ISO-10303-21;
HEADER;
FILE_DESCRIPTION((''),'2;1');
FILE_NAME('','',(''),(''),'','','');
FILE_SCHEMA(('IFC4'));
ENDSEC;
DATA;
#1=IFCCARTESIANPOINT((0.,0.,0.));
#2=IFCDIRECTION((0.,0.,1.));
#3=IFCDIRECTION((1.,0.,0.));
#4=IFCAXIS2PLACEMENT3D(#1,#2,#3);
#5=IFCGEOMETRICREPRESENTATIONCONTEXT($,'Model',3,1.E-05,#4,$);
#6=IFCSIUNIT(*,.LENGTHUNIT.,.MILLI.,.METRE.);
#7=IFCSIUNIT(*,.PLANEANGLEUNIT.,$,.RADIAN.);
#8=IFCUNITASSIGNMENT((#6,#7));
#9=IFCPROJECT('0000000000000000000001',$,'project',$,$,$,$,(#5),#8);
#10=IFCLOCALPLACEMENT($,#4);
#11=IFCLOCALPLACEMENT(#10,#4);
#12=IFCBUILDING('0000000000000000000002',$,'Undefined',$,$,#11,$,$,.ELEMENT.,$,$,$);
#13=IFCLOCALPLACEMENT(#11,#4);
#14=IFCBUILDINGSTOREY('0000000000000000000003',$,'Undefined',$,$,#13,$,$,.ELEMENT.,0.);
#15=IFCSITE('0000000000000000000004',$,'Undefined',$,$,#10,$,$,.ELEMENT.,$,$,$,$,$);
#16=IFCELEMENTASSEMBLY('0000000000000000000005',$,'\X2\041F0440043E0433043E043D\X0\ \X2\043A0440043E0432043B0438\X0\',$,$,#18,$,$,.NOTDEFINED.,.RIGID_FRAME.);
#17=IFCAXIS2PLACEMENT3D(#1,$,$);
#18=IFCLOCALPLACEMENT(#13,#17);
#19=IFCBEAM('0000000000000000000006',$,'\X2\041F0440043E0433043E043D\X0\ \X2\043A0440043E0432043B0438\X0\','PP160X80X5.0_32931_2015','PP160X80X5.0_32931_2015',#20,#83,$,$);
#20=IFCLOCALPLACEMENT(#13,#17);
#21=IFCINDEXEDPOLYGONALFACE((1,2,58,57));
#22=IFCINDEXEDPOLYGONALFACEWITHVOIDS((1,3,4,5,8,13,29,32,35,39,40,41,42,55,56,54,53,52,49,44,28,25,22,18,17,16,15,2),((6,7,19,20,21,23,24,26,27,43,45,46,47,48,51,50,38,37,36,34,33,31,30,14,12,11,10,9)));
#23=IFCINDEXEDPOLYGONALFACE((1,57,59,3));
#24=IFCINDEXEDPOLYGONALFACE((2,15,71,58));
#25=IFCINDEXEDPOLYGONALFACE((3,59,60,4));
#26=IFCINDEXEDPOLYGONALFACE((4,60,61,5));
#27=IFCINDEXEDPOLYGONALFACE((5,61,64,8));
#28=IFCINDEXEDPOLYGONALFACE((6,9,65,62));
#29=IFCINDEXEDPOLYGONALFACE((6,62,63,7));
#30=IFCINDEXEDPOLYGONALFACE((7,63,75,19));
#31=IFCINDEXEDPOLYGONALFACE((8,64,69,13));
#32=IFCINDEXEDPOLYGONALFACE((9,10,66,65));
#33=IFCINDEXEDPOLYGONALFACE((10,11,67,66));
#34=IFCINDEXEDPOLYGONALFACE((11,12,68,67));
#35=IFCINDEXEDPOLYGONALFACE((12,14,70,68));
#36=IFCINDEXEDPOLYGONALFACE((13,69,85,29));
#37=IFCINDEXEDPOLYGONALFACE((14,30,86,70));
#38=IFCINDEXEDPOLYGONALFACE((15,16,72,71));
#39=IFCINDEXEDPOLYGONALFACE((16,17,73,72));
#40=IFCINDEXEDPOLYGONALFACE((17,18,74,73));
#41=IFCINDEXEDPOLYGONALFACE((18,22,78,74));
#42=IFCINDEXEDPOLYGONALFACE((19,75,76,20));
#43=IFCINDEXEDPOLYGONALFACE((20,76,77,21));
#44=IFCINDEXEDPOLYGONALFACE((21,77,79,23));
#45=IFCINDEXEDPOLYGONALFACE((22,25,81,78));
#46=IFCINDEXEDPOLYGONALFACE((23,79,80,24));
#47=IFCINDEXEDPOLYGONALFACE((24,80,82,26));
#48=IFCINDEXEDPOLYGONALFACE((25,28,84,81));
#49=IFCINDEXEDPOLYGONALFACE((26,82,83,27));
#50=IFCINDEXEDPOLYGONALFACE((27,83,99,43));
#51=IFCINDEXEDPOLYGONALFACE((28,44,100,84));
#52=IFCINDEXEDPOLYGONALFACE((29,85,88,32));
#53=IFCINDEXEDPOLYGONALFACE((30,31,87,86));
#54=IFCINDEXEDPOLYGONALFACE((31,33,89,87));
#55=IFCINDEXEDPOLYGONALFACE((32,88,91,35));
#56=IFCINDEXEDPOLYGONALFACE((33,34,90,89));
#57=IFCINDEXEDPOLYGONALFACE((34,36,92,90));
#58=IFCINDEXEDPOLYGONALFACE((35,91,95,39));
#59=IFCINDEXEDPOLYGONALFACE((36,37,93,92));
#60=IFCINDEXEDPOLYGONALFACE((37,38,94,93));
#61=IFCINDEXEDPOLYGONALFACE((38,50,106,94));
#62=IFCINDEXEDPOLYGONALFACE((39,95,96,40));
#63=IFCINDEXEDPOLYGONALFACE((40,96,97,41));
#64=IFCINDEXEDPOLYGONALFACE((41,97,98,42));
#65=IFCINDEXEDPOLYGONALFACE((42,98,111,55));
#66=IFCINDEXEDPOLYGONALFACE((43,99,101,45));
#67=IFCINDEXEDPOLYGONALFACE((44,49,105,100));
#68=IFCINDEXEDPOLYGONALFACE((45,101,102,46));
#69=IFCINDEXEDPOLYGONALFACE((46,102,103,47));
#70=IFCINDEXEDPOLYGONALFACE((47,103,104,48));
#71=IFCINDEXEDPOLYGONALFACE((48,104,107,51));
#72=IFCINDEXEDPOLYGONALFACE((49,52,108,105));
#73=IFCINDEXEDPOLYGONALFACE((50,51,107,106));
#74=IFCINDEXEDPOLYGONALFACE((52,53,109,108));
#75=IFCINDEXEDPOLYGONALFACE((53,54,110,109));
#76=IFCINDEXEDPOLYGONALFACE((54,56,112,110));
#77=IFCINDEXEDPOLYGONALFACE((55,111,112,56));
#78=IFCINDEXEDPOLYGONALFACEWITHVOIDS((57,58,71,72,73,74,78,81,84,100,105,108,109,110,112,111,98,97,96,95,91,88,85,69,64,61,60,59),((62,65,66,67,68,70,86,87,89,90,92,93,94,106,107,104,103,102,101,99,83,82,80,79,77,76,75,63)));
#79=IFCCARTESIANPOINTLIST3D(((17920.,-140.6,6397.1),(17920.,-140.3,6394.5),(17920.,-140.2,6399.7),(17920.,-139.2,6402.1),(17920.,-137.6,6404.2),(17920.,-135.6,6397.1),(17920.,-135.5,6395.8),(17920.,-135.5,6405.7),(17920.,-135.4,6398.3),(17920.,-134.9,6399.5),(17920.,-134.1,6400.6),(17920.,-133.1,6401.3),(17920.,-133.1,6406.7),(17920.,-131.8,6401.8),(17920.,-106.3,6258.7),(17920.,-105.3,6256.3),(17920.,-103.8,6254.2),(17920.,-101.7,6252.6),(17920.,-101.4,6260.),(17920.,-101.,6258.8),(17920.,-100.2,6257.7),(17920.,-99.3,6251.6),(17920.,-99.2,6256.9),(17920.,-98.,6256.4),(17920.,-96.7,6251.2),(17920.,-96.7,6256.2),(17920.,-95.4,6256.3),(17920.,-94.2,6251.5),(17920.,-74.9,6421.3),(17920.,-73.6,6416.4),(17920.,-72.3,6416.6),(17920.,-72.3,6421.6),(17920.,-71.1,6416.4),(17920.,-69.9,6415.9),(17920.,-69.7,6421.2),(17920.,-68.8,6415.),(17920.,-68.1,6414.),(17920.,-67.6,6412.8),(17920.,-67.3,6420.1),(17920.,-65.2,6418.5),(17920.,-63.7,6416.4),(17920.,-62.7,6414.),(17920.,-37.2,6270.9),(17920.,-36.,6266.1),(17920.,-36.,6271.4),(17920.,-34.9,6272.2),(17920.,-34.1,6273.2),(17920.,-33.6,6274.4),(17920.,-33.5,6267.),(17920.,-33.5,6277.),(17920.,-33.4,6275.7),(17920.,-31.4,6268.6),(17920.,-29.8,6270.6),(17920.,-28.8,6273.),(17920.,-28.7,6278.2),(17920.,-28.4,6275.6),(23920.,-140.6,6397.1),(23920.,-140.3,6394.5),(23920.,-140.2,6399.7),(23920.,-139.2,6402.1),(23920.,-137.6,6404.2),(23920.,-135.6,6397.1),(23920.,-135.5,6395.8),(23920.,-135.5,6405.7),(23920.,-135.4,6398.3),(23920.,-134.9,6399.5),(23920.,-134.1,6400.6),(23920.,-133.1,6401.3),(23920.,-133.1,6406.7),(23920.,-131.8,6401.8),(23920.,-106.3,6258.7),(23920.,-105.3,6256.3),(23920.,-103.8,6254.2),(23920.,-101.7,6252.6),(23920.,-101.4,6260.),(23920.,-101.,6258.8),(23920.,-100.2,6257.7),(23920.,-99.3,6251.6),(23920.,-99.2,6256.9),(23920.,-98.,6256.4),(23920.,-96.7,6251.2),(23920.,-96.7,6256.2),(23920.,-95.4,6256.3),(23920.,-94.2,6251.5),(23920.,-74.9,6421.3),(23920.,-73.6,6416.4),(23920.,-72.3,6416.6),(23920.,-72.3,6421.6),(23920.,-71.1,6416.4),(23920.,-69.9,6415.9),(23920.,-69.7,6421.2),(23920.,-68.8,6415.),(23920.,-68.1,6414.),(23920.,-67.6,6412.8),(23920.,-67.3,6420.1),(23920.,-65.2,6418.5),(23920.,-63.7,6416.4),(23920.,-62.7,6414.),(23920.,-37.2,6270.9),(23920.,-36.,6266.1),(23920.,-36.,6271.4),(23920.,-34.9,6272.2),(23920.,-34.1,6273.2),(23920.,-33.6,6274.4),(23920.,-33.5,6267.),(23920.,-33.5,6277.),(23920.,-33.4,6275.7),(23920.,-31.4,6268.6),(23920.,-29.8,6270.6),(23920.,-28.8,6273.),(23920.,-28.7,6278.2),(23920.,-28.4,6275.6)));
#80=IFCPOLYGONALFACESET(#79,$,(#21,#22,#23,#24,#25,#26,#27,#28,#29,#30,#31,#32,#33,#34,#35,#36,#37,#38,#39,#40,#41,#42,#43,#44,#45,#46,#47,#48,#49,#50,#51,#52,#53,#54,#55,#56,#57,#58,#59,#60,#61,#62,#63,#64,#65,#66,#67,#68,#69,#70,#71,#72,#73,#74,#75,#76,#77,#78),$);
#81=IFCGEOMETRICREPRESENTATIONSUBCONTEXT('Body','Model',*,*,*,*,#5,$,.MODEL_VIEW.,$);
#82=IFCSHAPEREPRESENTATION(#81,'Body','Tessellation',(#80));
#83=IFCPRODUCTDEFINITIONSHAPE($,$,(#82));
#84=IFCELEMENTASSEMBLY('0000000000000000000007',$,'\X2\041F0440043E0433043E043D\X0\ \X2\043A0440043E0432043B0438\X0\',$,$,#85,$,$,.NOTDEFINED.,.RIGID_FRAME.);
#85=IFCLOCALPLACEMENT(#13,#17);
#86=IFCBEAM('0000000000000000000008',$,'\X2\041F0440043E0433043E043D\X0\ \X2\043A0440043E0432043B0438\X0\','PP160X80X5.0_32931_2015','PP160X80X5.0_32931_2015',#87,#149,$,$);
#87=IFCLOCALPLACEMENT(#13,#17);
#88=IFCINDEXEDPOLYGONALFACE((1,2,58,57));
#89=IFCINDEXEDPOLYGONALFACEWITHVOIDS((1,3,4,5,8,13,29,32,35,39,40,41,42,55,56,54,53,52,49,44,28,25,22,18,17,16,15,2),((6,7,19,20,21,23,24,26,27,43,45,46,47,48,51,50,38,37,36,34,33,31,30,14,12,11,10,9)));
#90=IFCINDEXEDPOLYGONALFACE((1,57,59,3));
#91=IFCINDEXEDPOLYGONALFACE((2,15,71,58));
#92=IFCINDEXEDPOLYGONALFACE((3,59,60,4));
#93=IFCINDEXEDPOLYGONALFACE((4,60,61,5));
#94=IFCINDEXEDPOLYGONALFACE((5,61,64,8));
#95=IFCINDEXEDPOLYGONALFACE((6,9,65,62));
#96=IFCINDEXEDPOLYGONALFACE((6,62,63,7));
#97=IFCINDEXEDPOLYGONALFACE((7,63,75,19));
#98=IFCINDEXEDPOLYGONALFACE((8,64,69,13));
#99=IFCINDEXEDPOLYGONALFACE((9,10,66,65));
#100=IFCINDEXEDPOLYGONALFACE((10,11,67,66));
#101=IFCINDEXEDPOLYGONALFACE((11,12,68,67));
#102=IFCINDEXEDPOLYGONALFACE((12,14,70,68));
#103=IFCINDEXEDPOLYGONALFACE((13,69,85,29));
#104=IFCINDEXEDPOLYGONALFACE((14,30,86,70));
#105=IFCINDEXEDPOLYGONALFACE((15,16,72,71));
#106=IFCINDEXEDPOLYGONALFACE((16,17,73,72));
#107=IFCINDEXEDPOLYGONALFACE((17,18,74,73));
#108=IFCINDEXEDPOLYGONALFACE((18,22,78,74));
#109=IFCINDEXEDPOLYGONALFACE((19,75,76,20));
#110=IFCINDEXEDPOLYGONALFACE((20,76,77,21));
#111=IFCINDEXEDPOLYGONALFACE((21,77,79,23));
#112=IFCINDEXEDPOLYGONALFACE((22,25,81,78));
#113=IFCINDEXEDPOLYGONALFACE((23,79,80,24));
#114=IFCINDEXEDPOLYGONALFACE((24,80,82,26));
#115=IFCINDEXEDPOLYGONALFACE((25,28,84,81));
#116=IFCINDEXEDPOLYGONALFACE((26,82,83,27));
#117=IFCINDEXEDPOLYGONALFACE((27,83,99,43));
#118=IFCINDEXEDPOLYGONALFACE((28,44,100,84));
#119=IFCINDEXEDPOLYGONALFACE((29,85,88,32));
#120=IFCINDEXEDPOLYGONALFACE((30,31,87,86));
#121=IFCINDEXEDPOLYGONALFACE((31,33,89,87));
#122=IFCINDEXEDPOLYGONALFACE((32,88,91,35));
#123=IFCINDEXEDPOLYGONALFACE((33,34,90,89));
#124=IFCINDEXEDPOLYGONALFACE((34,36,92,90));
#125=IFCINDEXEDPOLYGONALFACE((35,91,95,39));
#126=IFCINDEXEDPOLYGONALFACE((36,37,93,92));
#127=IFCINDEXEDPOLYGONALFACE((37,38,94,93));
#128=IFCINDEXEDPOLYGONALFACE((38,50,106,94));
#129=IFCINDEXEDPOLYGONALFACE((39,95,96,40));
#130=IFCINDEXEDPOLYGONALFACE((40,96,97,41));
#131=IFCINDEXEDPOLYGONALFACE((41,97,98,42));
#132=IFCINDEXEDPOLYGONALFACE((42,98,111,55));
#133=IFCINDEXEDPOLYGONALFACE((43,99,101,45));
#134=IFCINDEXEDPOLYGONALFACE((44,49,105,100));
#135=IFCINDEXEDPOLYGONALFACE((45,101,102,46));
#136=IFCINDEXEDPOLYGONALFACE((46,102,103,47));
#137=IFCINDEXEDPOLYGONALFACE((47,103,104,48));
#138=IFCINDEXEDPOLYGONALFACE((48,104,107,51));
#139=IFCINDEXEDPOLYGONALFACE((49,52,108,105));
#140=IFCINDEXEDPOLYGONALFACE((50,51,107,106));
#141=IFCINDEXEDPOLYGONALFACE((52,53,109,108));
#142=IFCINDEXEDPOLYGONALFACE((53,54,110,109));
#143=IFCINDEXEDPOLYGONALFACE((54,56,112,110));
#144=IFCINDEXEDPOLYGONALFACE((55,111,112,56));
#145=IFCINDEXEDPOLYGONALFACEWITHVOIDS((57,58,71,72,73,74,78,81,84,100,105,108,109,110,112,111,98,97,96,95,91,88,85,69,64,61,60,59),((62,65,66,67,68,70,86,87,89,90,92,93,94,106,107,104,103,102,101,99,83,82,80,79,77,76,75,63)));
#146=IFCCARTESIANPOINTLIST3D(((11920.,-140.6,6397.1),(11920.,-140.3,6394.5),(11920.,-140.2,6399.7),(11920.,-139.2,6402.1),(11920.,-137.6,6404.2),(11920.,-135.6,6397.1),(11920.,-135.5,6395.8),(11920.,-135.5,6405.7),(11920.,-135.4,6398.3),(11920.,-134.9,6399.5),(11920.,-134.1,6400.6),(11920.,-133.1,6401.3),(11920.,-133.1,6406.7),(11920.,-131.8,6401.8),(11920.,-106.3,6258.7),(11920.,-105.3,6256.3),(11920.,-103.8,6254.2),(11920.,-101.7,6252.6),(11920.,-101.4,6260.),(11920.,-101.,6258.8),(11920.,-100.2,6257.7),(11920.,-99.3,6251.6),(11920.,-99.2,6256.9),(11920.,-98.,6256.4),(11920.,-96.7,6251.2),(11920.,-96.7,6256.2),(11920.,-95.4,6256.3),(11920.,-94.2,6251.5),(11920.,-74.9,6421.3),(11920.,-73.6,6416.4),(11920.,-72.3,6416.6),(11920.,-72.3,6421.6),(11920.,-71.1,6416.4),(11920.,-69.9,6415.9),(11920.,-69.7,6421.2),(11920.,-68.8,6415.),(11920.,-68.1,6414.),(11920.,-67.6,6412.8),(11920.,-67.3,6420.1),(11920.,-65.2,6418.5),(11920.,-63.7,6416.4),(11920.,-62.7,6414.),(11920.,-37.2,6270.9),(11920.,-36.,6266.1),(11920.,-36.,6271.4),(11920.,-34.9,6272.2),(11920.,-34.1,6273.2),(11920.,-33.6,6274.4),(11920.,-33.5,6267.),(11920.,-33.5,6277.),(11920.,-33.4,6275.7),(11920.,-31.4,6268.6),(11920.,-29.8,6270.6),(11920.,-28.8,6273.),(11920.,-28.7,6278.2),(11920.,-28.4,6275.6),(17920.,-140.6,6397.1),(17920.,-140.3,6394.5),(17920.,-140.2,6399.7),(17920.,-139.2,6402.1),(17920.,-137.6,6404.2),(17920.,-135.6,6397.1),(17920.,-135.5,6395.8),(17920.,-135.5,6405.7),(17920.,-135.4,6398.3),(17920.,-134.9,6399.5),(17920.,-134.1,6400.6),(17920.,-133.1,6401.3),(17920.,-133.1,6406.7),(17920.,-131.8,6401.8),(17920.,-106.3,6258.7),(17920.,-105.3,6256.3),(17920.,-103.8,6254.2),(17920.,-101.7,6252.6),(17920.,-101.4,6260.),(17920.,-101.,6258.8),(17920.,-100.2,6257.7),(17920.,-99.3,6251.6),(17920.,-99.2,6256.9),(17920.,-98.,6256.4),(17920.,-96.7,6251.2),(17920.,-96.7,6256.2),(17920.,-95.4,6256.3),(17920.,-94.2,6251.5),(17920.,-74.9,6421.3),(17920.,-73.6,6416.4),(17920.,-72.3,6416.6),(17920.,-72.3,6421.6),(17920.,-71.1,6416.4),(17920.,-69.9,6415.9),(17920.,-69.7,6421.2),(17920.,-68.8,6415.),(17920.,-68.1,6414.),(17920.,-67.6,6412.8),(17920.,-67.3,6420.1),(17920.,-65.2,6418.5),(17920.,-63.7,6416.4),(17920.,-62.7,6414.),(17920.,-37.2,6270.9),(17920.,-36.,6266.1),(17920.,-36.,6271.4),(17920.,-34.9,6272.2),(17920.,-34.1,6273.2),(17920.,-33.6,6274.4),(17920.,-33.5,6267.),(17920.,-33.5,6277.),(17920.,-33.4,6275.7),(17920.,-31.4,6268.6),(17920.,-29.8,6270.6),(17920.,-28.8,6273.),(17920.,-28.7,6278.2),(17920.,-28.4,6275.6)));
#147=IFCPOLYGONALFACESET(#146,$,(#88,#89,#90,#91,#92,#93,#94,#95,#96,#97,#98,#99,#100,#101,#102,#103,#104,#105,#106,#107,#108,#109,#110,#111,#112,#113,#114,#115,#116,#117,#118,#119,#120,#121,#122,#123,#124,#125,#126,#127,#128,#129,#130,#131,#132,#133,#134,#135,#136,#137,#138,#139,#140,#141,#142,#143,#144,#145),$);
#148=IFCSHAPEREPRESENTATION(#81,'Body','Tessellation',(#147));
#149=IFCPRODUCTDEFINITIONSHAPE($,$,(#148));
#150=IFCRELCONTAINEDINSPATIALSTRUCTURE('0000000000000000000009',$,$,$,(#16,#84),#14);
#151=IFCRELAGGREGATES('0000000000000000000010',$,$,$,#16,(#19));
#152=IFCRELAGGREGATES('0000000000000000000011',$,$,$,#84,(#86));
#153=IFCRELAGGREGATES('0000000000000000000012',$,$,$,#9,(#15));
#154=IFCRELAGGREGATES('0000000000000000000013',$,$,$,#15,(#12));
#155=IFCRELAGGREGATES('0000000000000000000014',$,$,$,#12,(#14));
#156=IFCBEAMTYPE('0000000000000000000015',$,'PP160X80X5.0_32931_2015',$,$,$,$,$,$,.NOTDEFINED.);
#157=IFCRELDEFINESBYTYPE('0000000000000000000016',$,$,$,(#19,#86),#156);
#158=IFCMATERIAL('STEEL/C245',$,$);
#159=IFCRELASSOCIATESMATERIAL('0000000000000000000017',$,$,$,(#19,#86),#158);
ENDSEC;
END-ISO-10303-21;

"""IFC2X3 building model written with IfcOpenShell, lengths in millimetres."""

from ifc_helpers import new_model, si_unit, frame, origin_with_axes, origin_2d_with_axis, place, context, subcontext, project, spatial, hollow_rectangle, extrude, material, type_object, element, aggregate, save


model = new_model("IFC2X3")

# Units and contexts
model_context = context("Model", 3, precision=1e-05, world=origin_with_axes())
body_context = subcontext(model_context, "Body", "Model", "MODEL_VIEW")
ifc_project = project(units=[si_unit("LENGTHUNIT", "METRE", prefix="MILLI"), si_unit("PLANEANGLEUNIT", "RADIAN")], contexts=[model_context])

# Site, building, storey
site_placement = place(None, origin_with_axes())
site = spatial("IfcSite", under=ifc_project, at=site_placement, Name="Undefined", CompositionType="ELEMENT")
building_placement = place(site_placement, origin_with_axes())
building = spatial("IfcBuilding", under=site, at=building_placement, Name="Undefined", CompositionType="ELEMENT")
storey_placement = place(building_placement, origin_with_axes())
storey = spatial("IfcBuildingStorey", under=building, at=storey_placement, Name="Undefined", CompositionType="ELEMENT", Elevation=0.0)

# Shared definitions
ifc_material = material(Name="STEEL/C245")

# Element assemblies, beams
assembly_1_placement = place(storey_placement, origin_with_axes())
assembly_1 = element("IfcElementAssembly", 1, at=assembly_1_placement, inside=storey, Name="Прогон кровли", AssemblyPlace="NOTDEFINED", PredefinedType="RIGID_FRAME")
beam_type_1 = type_object("IfcBeamType", Name="PP160X80X5.0_32931_2015", PredefinedType="NOTDEFINED")
beam_1_placement = place(assembly_1_placement, frame((17920.0, -84.5, 6336.4), z_axis=(0.0, -0.243188, 0.969979), x_axis=(1.0, 0.0, 0.0)))
beam_1 = element("IfcBeam", 2, at=beam_1_placement, type_object=beam_type_1, material=ifc_material, Name="Прогон кровли", Description="PP160X80X5.0_32931_2015", ObjectType="PP160X80X5.0_32931_2015", context=body_context, shape_type="SweptSolid", body=[
    extrude(hollow_rectangle(XDim=80.0, YDim=160.0, WallThickness=5.0, InnerFilletRadius=5.0, OuterFilletRadius=10.0, at=origin_2d_with_axis()), frame((6000.0, 0.0, 0.0), z_axis=(-1.0, 0.0, 0.0), x_axis=(0.0, -1.0, 0.0)), (0.0, 0.0, 1.0), 6000.0),
])
aggregate(assembly_1, [beam_1])
assembly_2_placement = place(storey_placement, origin_with_axes())
assembly_2 = element("IfcElementAssembly", 3, at=assembly_2_placement, inside=storey, Name="Прогон кровли", AssemblyPlace="NOTDEFINED", PredefinedType="RIGID_FRAME")
beam_2_placement = place(assembly_2_placement, frame((11920.0, -84.5, 6336.4), z_axis=(0.0, -0.243188, 0.969979), x_axis=(1.0, 0.0, 0.0)))
beam_2 = element("IfcBeam", 4, at=beam_2_placement, type_object=beam_type_1, material=ifc_material, Name="Прогон кровли", Description="PP160X80X5.0_32931_2015", ObjectType="PP160X80X5.0_32931_2015", context=body_context, shape_type="SweptSolid", body=[
    extrude(hollow_rectangle(XDim=80.0, YDim=160.0, WallThickness=5.0, InnerFilletRadius=5.0, OuterFilletRadius=10.0, at=origin_2d_with_axis()), frame((6000.0, 0.0, 0.0), z_axis=(-1.0, 0.0, 0.0), x_axis=(0.0, -1.0, 0.0)), (0.0, 0.0, 1.0), 6000.0),
])
aggregate(assembly_2, [beam_2])

save(model, "model.ifc")
